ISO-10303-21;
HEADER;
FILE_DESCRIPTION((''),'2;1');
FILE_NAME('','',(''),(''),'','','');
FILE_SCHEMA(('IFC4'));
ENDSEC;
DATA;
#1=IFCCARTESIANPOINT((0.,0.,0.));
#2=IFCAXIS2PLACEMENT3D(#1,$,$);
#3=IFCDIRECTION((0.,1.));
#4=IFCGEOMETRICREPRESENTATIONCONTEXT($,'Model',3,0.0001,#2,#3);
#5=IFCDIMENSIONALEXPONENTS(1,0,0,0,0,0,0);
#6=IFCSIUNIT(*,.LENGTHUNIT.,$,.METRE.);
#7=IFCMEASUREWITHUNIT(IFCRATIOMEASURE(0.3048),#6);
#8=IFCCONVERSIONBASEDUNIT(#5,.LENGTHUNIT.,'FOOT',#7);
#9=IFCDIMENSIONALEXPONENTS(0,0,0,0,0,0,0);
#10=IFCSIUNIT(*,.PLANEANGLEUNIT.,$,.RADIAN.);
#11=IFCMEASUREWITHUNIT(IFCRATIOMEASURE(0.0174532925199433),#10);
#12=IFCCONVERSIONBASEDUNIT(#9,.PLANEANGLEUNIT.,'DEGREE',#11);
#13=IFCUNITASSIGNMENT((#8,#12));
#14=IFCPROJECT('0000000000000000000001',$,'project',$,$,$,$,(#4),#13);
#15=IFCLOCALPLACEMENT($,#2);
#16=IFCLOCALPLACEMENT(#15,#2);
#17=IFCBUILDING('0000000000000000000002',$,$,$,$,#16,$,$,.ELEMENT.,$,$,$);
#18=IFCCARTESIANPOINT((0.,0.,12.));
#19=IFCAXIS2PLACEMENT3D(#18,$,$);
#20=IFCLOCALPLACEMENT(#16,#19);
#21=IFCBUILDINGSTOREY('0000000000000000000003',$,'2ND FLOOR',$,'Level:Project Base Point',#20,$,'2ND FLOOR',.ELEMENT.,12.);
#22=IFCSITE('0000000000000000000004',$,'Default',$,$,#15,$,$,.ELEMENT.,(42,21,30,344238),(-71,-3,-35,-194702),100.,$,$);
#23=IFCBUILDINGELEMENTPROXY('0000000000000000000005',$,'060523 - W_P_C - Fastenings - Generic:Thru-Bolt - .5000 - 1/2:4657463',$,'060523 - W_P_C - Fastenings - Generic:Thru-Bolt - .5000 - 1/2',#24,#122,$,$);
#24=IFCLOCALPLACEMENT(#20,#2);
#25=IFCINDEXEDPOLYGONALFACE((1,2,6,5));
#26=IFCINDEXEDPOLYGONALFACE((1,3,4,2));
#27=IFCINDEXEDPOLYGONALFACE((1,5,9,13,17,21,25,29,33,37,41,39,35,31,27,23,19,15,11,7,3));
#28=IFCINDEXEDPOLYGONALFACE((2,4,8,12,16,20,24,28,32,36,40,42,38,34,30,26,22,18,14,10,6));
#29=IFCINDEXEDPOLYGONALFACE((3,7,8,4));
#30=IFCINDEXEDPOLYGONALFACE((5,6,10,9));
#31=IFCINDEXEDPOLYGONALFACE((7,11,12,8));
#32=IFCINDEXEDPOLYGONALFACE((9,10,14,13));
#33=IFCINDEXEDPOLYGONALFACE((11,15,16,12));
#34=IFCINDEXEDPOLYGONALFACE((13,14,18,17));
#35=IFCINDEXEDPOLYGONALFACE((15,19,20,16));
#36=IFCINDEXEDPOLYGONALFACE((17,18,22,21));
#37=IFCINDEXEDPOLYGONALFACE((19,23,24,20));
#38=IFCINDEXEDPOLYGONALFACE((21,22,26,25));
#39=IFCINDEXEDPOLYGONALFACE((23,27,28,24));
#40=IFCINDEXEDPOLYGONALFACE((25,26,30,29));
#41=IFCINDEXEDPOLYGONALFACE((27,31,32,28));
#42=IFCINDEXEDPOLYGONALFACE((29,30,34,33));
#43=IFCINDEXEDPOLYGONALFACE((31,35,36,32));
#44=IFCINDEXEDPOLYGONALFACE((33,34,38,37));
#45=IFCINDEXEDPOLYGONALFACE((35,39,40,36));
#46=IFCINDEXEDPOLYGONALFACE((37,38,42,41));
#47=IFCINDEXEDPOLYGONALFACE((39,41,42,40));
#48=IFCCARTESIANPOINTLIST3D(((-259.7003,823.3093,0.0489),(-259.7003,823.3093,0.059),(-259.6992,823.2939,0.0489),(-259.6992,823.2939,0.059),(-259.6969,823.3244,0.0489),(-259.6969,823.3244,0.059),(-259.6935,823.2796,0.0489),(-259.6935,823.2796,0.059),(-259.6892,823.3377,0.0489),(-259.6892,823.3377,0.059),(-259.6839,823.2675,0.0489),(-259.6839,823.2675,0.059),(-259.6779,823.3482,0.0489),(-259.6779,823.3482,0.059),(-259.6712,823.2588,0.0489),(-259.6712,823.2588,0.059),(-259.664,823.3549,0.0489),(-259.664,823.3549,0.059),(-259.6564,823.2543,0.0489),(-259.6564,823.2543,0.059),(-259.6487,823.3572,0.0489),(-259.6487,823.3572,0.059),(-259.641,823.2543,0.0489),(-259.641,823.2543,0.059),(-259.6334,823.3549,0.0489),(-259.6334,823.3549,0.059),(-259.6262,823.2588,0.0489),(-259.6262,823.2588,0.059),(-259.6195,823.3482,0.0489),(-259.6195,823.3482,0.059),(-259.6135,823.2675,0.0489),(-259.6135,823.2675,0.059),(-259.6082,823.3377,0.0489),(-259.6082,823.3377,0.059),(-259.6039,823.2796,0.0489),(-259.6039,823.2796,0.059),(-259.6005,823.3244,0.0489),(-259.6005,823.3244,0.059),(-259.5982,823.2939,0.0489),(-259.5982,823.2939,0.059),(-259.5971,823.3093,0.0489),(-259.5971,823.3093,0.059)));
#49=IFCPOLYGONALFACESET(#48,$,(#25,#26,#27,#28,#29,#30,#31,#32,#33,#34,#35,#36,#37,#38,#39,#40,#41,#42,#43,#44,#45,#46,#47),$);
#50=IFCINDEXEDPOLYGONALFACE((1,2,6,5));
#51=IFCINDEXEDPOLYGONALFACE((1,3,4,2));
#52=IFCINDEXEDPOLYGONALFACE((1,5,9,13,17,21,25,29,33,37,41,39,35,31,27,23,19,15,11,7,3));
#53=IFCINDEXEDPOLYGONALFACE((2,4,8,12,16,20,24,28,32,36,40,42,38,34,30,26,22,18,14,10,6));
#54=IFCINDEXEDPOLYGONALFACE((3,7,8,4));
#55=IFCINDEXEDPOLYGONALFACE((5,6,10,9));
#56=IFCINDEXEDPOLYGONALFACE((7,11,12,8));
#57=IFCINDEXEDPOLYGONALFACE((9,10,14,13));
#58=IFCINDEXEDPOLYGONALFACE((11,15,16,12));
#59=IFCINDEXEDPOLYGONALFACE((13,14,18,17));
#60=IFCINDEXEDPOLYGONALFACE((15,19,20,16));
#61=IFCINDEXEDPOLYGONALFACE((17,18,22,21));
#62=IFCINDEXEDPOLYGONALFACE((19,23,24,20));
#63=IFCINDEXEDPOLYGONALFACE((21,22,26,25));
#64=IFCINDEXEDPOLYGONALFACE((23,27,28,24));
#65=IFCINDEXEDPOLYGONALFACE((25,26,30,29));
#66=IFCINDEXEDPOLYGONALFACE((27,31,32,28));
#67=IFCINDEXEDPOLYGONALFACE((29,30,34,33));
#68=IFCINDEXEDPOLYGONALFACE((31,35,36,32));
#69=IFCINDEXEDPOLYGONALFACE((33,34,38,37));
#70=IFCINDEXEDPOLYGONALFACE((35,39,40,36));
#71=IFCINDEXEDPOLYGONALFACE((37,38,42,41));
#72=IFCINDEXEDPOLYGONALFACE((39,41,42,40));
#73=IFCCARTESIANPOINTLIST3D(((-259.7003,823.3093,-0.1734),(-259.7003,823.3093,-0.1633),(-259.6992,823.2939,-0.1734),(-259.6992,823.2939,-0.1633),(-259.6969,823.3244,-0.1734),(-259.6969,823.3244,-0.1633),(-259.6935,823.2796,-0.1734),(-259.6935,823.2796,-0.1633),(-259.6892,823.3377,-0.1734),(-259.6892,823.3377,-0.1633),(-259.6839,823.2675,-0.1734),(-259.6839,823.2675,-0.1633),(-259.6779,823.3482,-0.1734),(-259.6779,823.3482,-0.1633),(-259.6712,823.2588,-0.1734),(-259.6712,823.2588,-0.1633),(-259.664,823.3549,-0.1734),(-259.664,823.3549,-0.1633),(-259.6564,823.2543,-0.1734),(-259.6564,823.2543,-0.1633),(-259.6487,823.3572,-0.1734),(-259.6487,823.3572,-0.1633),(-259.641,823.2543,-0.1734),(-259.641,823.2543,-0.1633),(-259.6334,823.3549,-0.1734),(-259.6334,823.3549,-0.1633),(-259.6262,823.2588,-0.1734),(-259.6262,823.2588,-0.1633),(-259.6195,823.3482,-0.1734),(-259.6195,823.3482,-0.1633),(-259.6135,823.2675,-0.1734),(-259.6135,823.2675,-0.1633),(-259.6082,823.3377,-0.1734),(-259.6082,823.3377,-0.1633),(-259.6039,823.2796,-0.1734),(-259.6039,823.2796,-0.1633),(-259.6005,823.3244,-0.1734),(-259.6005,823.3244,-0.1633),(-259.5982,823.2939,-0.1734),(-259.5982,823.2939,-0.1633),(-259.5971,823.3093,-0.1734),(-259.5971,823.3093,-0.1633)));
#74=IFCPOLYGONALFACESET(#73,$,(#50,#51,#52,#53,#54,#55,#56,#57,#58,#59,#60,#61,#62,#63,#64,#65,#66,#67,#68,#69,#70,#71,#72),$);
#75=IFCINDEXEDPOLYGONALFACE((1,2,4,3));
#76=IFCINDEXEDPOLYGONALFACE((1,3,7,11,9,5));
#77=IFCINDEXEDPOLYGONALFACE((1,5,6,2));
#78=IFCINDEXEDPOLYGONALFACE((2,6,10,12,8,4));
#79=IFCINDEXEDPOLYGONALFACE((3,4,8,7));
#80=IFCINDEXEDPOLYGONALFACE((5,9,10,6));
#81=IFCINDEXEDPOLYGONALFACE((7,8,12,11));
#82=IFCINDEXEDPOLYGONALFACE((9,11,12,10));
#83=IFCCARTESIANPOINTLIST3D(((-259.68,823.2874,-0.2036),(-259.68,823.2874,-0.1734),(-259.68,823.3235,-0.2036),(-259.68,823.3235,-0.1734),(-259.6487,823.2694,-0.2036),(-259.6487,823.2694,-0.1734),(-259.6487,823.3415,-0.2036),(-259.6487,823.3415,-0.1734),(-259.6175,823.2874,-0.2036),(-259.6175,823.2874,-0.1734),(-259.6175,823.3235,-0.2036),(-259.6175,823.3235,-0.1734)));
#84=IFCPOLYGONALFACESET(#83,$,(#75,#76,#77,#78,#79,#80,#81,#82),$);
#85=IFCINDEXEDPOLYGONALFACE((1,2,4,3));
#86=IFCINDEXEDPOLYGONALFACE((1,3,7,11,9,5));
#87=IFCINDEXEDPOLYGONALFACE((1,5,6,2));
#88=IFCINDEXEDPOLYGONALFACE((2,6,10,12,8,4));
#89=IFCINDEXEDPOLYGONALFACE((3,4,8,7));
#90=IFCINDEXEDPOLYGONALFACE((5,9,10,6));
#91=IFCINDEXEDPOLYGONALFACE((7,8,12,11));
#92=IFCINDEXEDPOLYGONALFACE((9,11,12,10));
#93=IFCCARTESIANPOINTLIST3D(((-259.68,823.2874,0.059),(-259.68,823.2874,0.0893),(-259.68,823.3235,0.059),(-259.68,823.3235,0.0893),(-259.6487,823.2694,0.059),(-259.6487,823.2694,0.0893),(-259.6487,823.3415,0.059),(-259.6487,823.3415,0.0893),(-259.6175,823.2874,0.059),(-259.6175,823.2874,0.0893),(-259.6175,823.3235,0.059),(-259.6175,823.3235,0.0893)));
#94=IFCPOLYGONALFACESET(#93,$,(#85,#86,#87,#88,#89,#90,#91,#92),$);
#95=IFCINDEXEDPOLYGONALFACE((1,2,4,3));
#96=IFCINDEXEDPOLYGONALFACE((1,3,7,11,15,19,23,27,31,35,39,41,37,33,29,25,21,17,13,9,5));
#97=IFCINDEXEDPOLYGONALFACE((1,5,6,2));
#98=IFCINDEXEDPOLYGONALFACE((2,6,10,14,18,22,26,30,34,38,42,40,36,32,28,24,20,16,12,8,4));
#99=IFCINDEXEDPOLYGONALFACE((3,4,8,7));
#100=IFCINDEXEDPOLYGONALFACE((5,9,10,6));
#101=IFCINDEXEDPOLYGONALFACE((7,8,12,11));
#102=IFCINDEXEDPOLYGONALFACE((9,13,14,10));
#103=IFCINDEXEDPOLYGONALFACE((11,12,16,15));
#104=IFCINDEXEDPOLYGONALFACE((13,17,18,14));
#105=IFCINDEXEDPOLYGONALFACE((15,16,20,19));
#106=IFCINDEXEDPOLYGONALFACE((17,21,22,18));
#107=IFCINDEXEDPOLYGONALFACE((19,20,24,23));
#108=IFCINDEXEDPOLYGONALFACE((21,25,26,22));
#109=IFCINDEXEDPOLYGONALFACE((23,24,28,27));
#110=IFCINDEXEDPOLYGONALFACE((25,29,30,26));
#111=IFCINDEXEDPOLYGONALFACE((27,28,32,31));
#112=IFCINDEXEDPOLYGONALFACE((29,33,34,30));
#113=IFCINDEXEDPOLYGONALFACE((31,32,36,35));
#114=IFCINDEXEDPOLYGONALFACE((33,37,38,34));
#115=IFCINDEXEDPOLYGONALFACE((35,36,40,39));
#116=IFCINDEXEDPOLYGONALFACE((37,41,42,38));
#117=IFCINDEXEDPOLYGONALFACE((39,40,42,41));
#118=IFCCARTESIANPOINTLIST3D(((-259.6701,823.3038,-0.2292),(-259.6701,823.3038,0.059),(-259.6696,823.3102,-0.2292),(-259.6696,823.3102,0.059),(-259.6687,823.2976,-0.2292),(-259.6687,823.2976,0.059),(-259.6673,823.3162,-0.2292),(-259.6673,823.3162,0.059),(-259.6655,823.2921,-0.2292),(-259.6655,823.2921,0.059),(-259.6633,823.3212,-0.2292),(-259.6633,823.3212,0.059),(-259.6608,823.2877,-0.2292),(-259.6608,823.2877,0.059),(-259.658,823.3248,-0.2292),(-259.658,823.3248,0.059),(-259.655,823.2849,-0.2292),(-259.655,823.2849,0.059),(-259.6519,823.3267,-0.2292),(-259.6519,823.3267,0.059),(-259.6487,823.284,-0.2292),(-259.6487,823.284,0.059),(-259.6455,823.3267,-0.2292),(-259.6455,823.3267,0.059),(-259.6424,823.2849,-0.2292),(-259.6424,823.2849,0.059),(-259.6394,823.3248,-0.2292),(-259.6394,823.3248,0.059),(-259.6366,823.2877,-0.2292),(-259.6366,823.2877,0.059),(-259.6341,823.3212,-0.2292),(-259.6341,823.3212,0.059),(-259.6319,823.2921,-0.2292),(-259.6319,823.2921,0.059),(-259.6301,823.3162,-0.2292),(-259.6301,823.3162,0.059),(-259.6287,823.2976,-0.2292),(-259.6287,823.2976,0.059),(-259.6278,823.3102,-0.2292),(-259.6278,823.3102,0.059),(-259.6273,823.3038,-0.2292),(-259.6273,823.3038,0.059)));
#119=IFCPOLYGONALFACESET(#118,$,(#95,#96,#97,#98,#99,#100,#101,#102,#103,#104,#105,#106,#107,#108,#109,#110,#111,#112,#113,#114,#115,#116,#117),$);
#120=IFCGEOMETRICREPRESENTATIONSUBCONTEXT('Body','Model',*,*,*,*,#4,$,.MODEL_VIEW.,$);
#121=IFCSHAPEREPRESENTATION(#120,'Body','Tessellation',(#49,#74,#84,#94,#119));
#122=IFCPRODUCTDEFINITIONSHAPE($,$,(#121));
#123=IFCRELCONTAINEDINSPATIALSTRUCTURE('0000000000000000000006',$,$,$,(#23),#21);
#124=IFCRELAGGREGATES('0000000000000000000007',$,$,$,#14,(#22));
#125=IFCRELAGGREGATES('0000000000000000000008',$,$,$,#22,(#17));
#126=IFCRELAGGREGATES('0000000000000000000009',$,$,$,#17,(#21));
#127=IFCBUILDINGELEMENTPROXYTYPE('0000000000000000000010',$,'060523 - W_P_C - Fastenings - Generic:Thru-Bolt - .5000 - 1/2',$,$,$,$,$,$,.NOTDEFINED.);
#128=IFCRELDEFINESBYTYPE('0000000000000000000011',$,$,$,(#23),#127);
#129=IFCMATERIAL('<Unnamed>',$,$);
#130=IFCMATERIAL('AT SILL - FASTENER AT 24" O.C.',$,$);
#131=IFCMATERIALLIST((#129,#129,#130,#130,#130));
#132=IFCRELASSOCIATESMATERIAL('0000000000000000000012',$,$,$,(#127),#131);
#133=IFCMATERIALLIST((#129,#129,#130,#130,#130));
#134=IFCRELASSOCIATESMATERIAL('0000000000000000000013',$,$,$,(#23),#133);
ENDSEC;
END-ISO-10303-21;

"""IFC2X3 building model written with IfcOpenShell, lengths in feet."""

from ifc_helpers import new_model, entity, si_unit, converted_unit, direction, frame, frame_2d, origin, place, context, subcontext, project, spatial, polyline, circle, outline, extrude, source, transform, mapped, material, material_list, type_object, type_shapes, element, save


model = new_model("IFC2X3")

# Units and contexts
model_context = context("Model", 3, precision=0.0001, world=origin(), true_north=direction((0.0, 1.0)))
body_context = subcontext(model_context, "Body", "Model", "MODEL_VIEW")
ifc_project = project(units=[converted_unit("LENGTHUNIT", "FOOT", entity("IfcRatioMeasure", 0.3048), si_unit("LENGTHUNIT", "METRE"), dimensions=[1, 0, 0, 0, 0, 0, 0]), converted_unit("PLANEANGLEUNIT", "DEGREE", entity("IfcRatioMeasure", 0.0174532925199433), si_unit("PLANEANGLEUNIT", "RADIAN"), dimensions=[0, 0, 0, 0, 0, 0, 0])], contexts=[model_context])

# Site, building, storey
site_placement = place(None, origin())
site = spatial("IfcSite", under=ifc_project, at=site_placement, Name="Default", CompositionType="ELEMENT", RefLatitude=(42, 21, 30, 344238), RefLongitude=(-71, -3, -35, -194702), RefElevation=100.0)
building_placement = place(site_placement, origin())
building = spatial("IfcBuilding", under=site, at=building_placement, CompositionType="ELEMENT")
storey_placement = place(building_placement, frame((0.0, 0.0, 12.0)))
storey = spatial("IfcBuildingStorey", under=building, at=storey_placement, Name="2ND FLOOR", ObjectType="Level:Project Base Point", LongName="2ND FLOOR", CompositionType="ELEMENT", Elevation=12.0)

# Building element proxy
ifc_material_1 = material(Name="<Unnamed>")
ifc_material_2 = material(Name="AT SILL - FASTENER AT 24\" O.C.")
ifc_material_list_1 = material_list([ifc_material_1, ifc_material_1, ifc_material_2, ifc_material_2, ifc_material_2])
ifc_material_list_2 = material_list([ifc_material_1, ifc_material_1, ifc_material_2, ifc_material_2, ifc_material_2])
building_element_proxy_type_1 = type_object("IfcBuildingElementProxyType", Name="060523 - W_P_C - Fastenings - Generic:Thru-Bolt - .5000 - 1/2", PredefinedType="NOTDEFINED", material=ifc_material_list_2)
shared_shape_1 = source(origin(), body_context, "Body", "SweptSolid", [
    extrude(circle(Radius=0.0518, at=frame_2d((0.0, 0.0), x_axis=(1.0, 0.0))), frame((0.0, 0.0, 0.0), z_axis=(0.0, 0.0, 1.0), x_axis=(0.0, 1.0, 0.0)), (0.0, 0.0, 1.0), 0.0101),
    extrude(circle(Radius=0.0518, at=frame_2d((0.0, 0.0), x_axis=(1.0, 0.0))), frame((0.0, 0.0, -0.2223), z_axis=(0.0, 0.0, 1.0), x_axis=(0.0, 1.0, 0.0)), (0.0, 0.0, 1.0), 0.0101),
    extrude(outline(polyline([(-0.018, -0.0313), (0.018, -0.0313), (0.0361, 0.0), (0.018, 0.0313), (-0.018, 0.0313), (-0.0361, 0.0), (-0.018, -0.0313)])), frame((0.0, 0.0, -0.2526), z_axis=(0.0, 0.0, 1.0), x_axis=(0.0, -1.0, 0.0)), (0.0, 0.0, 1.0), 0.0303),
    extrude(outline(polyline([(-0.018, -0.0313), (0.018, -0.0313), (0.0361, 0.0), (0.018, 0.0312), (-0.018, 0.0312), (-0.0361, 0.0), (-0.018, -0.0313)])), frame((0.0, 0.0, 0.0101), z_axis=(0.0, 0.0, 1.0), x_axis=(0.866025, -0.5, 0.0)), (0.0, 0.0, 1.0), 0.0303),
    extrude(circle(Radius=0.0215, at=frame_2d((0.0, 0.0), x_axis=(1.0, 0.0))), frame((0.0, 0.0, -0.2781), z_axis=(0.0, 0.0, 1.0), x_axis=(0.0, -1.0, 0.0)), (0.0, 0.0, 1.0), 0.2882),
])
type_shapes(building_element_proxy_type_1, [shared_shape_1])
proxy_1_placement = place(storey_placement, frame((-259.6487, 823.3055, 0.0489)))
element("IfcBuildingElementProxy", 1, at=proxy_1_placement, inside=storey, type_object=building_element_proxy_type_1, material=ifc_material_list_1, Name="060523 - W_P_C - Fastenings - Generic:Thru-Bolt - .5000 - 1/2:4657463", ObjectType="060523 - W_P_C - Fastenings - Generic:Thru-Bolt - .5000 - 1/2", context=body_context, shape_type="MappedRepresentation", body=[
    mapped(shared_shape_1, transform((0.0, 0.0, 0.0), scale=1.0)),
])

save(model, "model.ifc")
